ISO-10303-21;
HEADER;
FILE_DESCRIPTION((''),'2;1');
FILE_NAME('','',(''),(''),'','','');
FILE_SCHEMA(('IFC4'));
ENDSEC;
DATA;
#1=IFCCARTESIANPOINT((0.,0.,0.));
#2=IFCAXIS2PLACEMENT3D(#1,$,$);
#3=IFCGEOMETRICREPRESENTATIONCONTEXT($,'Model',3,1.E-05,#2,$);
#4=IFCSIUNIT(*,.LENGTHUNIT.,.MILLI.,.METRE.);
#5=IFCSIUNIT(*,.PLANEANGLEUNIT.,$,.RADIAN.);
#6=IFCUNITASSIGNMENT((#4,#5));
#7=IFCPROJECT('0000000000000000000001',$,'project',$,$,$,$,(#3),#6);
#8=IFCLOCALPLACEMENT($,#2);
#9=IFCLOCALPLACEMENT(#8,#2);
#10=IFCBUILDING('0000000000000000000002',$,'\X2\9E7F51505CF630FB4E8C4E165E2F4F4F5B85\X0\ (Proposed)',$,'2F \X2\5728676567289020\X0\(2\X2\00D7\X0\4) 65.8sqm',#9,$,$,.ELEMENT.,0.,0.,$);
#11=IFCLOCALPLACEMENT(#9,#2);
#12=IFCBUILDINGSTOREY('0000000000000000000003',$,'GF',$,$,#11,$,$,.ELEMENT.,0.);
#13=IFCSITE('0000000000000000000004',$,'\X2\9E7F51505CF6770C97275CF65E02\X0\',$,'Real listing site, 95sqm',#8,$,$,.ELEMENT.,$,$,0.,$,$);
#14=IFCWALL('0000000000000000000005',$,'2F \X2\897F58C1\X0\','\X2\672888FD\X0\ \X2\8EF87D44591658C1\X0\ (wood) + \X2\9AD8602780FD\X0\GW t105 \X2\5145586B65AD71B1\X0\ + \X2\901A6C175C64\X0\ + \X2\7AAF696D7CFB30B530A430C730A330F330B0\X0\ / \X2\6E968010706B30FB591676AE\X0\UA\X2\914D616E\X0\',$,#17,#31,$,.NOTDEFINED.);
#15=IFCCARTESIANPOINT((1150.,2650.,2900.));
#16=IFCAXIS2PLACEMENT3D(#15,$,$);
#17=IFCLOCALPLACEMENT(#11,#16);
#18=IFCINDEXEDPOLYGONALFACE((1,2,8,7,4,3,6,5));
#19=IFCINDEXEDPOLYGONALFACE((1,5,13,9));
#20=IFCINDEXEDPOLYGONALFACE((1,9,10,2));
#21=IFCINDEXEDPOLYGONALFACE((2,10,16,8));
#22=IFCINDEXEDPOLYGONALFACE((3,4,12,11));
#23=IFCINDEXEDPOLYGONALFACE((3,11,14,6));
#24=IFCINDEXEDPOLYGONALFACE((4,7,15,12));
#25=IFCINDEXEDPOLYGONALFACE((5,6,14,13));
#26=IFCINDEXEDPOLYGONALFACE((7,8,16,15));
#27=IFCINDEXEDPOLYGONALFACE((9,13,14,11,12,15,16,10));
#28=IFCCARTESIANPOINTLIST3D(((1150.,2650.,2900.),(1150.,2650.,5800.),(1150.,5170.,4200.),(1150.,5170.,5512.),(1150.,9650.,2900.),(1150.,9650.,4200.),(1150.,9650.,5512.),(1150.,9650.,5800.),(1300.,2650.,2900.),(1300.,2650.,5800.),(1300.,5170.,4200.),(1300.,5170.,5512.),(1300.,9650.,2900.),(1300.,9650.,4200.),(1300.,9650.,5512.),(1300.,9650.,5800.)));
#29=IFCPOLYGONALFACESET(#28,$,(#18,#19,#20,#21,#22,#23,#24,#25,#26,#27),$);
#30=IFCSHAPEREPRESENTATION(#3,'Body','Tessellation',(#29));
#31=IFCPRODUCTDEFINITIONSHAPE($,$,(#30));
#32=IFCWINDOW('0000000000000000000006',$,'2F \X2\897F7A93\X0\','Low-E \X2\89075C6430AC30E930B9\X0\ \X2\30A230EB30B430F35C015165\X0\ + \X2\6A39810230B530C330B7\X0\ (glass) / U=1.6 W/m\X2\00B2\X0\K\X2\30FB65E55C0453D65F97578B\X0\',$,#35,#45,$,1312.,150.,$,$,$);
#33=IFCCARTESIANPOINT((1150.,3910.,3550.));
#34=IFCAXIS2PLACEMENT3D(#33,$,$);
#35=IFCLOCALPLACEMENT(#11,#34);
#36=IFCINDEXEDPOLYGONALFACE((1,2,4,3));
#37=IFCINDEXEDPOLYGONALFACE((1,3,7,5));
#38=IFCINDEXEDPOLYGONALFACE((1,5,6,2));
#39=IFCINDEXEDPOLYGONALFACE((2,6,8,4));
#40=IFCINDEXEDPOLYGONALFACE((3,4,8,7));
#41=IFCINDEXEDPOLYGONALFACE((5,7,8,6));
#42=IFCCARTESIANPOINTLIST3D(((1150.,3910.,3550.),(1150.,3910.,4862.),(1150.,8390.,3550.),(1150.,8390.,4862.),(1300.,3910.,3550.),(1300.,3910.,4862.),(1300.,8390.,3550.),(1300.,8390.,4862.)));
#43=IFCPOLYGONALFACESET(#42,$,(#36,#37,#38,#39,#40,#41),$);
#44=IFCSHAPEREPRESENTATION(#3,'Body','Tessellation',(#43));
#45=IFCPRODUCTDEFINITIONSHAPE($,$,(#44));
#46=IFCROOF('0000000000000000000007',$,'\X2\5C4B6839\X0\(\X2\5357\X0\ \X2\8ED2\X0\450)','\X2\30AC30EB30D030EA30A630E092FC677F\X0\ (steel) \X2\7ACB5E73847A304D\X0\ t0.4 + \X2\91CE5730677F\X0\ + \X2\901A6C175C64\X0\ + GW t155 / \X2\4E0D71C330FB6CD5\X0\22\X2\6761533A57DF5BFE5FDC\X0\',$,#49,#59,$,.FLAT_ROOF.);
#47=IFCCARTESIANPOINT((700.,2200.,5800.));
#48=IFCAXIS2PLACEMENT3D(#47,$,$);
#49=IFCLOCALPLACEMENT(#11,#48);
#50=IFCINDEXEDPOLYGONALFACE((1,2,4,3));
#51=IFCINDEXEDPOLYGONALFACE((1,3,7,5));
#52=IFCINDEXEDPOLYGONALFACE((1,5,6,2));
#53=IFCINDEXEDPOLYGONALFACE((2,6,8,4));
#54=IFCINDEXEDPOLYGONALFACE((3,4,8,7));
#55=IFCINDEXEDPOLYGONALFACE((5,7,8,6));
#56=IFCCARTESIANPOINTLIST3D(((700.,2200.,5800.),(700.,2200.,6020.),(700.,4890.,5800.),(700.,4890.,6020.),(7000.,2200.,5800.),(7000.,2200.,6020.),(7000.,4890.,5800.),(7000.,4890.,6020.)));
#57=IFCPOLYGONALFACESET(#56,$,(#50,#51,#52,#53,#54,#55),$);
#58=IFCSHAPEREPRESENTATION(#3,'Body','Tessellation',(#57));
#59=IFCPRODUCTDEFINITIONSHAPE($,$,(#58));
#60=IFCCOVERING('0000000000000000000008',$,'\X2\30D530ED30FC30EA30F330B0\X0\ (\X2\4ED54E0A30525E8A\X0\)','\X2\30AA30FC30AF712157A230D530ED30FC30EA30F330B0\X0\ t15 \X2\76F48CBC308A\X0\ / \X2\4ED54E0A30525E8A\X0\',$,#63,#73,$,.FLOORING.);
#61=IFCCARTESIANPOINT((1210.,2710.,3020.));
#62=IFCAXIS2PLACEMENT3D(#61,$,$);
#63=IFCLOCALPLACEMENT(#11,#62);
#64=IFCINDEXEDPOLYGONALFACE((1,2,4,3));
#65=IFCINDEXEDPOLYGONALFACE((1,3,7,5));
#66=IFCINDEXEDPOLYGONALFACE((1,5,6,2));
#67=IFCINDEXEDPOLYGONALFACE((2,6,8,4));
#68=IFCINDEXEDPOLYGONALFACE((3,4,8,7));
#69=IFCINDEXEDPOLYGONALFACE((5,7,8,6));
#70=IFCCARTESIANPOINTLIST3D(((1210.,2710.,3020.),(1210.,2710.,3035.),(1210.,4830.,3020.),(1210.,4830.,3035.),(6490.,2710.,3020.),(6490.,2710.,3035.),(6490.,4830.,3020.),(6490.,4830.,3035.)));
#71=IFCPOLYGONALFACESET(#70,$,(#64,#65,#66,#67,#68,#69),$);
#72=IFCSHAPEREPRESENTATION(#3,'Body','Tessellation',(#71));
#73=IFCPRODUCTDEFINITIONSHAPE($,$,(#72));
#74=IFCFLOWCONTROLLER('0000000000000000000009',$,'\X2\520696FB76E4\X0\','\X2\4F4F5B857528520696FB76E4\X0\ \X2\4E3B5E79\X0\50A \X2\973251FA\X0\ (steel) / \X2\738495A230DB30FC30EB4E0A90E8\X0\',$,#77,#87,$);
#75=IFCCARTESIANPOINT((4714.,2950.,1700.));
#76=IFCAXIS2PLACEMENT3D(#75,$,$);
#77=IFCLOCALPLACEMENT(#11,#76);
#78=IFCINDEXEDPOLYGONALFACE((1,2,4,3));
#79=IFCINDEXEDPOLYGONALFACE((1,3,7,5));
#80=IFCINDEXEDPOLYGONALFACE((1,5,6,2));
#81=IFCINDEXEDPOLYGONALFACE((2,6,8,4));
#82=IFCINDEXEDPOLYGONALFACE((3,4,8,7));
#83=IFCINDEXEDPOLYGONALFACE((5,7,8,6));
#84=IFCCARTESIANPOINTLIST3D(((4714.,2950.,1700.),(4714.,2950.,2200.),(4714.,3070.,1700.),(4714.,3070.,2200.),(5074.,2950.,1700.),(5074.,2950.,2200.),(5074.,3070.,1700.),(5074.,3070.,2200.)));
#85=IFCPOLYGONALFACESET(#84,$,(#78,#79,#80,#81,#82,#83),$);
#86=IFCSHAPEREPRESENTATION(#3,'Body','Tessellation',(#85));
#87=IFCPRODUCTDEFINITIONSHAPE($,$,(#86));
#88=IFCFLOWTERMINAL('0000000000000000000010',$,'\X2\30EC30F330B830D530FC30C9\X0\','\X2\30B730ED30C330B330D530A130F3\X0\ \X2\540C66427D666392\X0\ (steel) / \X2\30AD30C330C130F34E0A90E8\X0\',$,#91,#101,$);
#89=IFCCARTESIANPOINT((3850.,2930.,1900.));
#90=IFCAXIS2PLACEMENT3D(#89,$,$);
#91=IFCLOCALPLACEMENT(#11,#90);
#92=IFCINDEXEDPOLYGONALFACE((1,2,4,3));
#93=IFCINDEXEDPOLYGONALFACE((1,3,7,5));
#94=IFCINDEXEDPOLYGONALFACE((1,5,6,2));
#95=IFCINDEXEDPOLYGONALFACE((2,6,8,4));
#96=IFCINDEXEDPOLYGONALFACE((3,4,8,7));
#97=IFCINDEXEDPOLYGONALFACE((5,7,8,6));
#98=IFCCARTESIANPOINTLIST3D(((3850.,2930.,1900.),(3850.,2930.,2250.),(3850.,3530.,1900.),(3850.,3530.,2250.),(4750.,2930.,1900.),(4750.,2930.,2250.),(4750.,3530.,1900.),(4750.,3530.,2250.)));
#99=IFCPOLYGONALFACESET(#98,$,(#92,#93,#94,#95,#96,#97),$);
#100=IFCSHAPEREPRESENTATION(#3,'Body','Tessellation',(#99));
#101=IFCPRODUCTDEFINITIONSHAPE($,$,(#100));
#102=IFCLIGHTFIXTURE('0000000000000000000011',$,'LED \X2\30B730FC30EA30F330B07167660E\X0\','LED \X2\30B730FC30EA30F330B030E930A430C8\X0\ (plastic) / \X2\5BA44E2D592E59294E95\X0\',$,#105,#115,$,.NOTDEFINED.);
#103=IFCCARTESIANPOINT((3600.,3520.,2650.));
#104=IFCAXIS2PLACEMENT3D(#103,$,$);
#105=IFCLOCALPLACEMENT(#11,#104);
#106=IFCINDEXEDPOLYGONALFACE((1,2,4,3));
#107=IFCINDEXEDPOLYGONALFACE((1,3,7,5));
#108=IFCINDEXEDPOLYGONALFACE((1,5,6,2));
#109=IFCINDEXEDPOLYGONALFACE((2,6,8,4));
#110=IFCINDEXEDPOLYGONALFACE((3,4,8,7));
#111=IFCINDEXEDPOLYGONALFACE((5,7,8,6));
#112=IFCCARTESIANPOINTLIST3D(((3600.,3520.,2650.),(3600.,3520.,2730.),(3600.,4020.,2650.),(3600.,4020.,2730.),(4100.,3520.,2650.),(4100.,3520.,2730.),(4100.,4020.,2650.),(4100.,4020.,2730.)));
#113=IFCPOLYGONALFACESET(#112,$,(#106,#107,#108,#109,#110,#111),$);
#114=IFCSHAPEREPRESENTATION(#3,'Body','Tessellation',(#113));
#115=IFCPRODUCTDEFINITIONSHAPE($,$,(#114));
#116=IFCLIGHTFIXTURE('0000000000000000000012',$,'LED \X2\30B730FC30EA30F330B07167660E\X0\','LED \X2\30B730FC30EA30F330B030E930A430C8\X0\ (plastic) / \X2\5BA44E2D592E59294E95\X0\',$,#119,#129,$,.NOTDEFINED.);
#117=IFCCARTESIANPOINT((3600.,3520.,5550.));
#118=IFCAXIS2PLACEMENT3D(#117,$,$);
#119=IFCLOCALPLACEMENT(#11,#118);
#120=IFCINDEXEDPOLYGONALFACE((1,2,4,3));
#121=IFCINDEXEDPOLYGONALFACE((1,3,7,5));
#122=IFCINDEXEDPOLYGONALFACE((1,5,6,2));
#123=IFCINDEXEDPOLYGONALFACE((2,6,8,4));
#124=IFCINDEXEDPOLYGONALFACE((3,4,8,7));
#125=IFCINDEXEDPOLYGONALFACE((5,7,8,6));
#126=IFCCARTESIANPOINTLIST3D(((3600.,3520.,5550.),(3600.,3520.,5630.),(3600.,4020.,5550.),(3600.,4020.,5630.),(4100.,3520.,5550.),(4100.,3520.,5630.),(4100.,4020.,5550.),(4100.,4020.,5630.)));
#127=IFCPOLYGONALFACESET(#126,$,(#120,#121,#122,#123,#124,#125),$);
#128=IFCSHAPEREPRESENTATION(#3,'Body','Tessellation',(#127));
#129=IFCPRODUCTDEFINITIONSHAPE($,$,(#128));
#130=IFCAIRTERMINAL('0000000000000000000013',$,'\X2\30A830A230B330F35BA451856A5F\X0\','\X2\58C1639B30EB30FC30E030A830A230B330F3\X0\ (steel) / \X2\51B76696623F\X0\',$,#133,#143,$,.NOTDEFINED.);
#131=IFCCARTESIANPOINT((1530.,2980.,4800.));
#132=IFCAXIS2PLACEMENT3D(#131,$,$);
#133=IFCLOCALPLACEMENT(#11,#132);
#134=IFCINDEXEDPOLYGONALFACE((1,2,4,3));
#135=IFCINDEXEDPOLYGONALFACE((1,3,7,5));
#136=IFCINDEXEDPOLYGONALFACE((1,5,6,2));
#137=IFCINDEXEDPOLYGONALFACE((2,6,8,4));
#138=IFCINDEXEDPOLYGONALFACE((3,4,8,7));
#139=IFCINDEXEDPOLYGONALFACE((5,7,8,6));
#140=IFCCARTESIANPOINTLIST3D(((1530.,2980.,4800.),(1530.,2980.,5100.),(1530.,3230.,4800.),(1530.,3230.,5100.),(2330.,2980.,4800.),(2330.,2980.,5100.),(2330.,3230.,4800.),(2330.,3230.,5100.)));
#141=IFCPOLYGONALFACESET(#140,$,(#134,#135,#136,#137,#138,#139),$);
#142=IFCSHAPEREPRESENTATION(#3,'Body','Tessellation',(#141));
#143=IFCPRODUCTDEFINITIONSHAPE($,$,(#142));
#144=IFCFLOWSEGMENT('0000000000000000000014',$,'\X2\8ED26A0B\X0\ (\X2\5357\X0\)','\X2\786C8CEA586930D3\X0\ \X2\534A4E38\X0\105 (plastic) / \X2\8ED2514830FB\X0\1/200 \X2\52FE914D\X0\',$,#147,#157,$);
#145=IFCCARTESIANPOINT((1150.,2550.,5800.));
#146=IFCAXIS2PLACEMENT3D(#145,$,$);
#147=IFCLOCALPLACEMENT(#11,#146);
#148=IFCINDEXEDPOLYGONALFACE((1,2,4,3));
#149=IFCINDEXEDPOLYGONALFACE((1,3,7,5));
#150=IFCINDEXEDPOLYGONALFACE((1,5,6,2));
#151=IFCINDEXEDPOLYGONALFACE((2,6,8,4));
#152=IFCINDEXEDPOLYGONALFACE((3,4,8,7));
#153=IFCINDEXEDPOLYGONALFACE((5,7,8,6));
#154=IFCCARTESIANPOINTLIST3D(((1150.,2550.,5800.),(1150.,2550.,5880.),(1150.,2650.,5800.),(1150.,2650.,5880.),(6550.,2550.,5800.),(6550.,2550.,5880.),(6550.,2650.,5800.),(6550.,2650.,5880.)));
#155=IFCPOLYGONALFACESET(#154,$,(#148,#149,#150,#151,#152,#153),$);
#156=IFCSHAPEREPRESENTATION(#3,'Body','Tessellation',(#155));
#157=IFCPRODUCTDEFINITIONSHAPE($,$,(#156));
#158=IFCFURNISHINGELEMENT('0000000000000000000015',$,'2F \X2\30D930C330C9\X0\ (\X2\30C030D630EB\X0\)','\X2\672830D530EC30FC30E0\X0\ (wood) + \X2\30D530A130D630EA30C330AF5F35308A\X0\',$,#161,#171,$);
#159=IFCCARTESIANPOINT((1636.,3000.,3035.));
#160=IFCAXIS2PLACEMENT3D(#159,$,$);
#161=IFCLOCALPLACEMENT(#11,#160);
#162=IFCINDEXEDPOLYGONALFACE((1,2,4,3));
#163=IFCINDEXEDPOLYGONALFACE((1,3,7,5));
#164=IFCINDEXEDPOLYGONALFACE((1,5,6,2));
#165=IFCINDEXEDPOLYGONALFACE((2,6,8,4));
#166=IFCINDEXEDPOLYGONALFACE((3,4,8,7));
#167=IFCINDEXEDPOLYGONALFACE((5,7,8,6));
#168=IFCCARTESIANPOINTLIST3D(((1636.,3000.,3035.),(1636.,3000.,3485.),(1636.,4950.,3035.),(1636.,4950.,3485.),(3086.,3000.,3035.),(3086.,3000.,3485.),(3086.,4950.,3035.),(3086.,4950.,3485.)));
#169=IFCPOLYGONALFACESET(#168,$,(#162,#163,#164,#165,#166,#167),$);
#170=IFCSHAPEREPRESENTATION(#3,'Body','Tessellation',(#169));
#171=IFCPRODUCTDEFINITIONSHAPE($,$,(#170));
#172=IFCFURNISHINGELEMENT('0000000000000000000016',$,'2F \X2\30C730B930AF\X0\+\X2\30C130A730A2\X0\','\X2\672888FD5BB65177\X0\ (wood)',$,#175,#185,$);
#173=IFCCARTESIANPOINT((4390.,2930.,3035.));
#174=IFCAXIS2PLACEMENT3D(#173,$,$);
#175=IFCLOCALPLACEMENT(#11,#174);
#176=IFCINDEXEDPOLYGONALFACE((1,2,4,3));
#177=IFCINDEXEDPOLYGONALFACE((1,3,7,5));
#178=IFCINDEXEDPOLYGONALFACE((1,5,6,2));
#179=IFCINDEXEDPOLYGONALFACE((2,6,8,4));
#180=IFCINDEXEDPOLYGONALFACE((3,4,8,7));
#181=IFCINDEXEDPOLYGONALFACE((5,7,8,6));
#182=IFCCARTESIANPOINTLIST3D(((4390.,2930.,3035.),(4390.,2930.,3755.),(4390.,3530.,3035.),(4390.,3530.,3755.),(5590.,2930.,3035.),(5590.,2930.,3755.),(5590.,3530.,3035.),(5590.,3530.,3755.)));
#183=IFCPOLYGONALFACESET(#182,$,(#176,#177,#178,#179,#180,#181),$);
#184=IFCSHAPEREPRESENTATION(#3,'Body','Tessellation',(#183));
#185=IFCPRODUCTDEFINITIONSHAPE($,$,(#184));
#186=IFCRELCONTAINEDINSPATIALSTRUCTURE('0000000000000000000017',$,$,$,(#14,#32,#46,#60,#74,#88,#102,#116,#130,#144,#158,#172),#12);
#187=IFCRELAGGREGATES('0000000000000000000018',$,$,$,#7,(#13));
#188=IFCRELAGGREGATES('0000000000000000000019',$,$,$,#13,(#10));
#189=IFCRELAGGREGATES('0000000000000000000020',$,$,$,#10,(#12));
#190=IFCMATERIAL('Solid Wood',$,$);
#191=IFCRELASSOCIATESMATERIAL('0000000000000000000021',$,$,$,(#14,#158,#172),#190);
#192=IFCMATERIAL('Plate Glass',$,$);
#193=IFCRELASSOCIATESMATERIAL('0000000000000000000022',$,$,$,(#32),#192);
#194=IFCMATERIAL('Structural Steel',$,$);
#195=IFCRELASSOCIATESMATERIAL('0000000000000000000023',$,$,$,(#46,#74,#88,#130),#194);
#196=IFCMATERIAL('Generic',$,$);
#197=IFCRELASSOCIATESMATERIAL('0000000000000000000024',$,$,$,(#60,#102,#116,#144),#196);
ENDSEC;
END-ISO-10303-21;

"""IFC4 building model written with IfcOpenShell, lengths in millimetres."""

from ifc_helpers import new_model, si_unit, frame, frame_2d, origin, place, context, project, spatial, rectangle, extrude, material, element, fill, save


model = new_model("IFC4")

# Units and contexts
model_context = context("Model", 3, precision=1e-05, world=origin())
ifc_project = project(units=[si_unit("LENGTHUNIT", "METRE", prefix="MILLI"), si_unit("PLANEANGLEUNIT", "RADIAN")], contexts=[model_context])

# Site, building, storey
site_placement = place(None, origin())
site = spatial("IfcSite", under=ifc_project, at=site_placement, Name="鹿児島県霧島市", ObjectType="Real listing site, 95sqm", CompositionType="ELEMENT", RefElevation=0.0)
building_placement = place(site_placement, origin())
building = spatial("IfcBuilding", under=site, at=building_placement, Name="鹿児島・二世帯住宅 (Proposed)", ObjectType="2F 在来木造(2×4) 65.8sqm", CompositionType="ELEMENT", ElevationOfRefHeight=0.0, ElevationOfTerrain=0.0)
storey_placement = place(building_placement, origin())
storey = spatial("IfcBuildingStorey", under=building, at=storey_placement, Name="GF", CompositionType="ELEMENT", Elevation=0.0)

# Shared definitions
ifc_material_1 = material(Name="Solid Wood")

# Wall, opening, window
ifc_material_2 = material(Name="Plate Glass")
wall_1_placement = place(storey_placement, frame((1150.0, 2650.0, 2900.0)))
wall_1 = element("IfcWall", 1, at=wall_1_placement, inside=storey, material=ifc_material_1, Name="2F 西壁", Description="木製 軸組外壁 (wood) + 高性能GW t105 充填断熱 + 通気層 + 窯業系サイディング / 準耐火・外皮UA配慮", PredefinedType="NOTDEFINED", context=model_context, shape_type="SweptSolid", body=[
    extrude(rectangle(XDim=150.0, YDim=7000.0, at=frame_2d((75.0, 3500.0))), frame((1150.0, 2650.0, 2900.0)), (0.0, 0.0, 1.0), 2900.0),
])
opening_1_placement = place(storey_placement, frame((1150.0, 3910.0, 3550.0)))
opening_1 = element("IfcOpeningElement", 2, at=opening_1_placement, cuts=wall_1, PredefinedType="NOTDEFINED", context=model_context, shape_type="SweptSolid", body=[
    extrude(rectangle(XDim=150.0, YDim=4480.0, at=frame_2d((75.0, 2240.0))), frame((1150.0, 3910.0, 3550.0)), (0.0, 0.0, 1.0), 1312.0),
])
window_1_placement = place(storey_placement, frame((1150.0, 3910.0, 3550.0)))
window_1 = element("IfcWindow", 3, at=window_1_placement, inside=storey, material=ifc_material_2, Name="2F 西窓", Description="Low-E 複層ガラス アルゴン封入 + 樹脂サッシ (glass) / U=1.6 W/m²K・日射取得型", OverallHeight=1312.0, OverallWidth=150.0, context=model_context, shape_type="SweptSolid", body=[
    extrude(rectangle(XDim=150.0, YDim=4480.0, at=frame_2d((75.0, 2240.0))), frame((1150.0, 3910.0, 3550.0)), (0.0, 0.0, 1.0), 1312.0),
])
fill(opening_1, window_1)

# Roof
ifc_material_3 = material(Name="Structural Steel")
for number, where, name in (
    (4, (700.0, 2200.0, 5800.0), "屋根(南 軒450)"),
):
    element("IfcRoof", number, at=place(storey_placement, frame(where)), inside=storey, material=ifc_material_3, Name=name, Description="ガルバリウム鋼板 (steel) 立平葺き t0.4 + 野地板 + 通気層 + GW t155 / 不燃・法22条区域対応", PredefinedType="FLAT_ROOF", context=model_context, shape_type="SweptSolid", body=[
        extrude(rectangle(XDim=6300.0, YDim=2690.0, at=frame_2d((3150.0, 1345.0))), frame((700.0, 2200.0, 5800.0)), (0.0, 0.0, 1.0), 220.0),
    ])

# Covering
ifc_material_4 = material(Name="Generic")
covering_placement = place(storey_placement, frame((1210.0, 2710.0, 3020.0)))
element("IfcCovering", 5, at=covering_placement, inside=storey, material=ifc_material_4, Name="フローリング (仕上げ床)", Description="オーク無垢フローリング t15 直貼り / 仕上げ床", PredefinedType="FLOORING", context=model_context, shape_type="SweptSolid", body=[
    extrude(rectangle(XDim=5280.0, YDim=2120.0, at=frame_2d((2640.0, 1060.0))), frame((1210.0, 2710.0, 3020.0)), (0.0, 0.0, 1.0), 15.0),
])

# Flow controller
flow_controller_placement = place(storey_placement, frame((4714.0, 2950.0, 1700.0)))
element("IfcFlowController", 6, at=flow_controller_placement, inside=storey, material=ifc_material_3, Name="分電盤", Description="住宅用分電盤 主幹50A 露出 (steel) / 玄関ホール上部", context=model_context, shape_type="SweptSolid", body=[
    extrude(rectangle(XDim=360.0, YDim=120.0, at=frame_2d((180.0, 60.0))), frame((4714.0, 2950.0, 1700.0)), (0.0, 0.0, 1.0), 500.0),
])

# Flow terminal
flow_terminal_placement = place(storey_placement, frame((3850.0, 2930.0, 1900.0)))
element("IfcFlowTerminal", 7, at=flow_terminal_placement, inside=storey, material=ifc_material_3, Name="レンジフード", Description="シロッコファン 同時給排 (steel) / キッチン上部", context=model_context, shape_type="SweptSolid", body=[
    extrude(rectangle(XDim=900.0, YDim=600.0, at=frame_2d((450.0, 300.0))), frame((3850.0, 2930.0, 1900.0)), (0.0, 0.0, 1.0), 350.0),
])

# Light fixtures
light_fixture_1_placement = place(storey_placement, frame((3600.0, 3520.0, 2650.0)))
element("IfcLightFixture", 8, at=light_fixture_1_placement, inside=storey, material=ifc_material_4, Name="LED シーリング照明", Description="LED シーリングライト (plastic) / 室中央天井", PredefinedType="NOTDEFINED", context=model_context, shape_type="SweptSolid", body=[
    extrude(rectangle(XDim=500.0, YDim=500.0, at=frame_2d((250.0, 250.0))), frame((3600.0, 3520.0, 2650.0)), (0.0, 0.0, 1.0), 80.0),
])
light_fixture_2_placement = place(storey_placement, frame((3600.0, 3520.0, 5550.0)))
element("IfcLightFixture", 9, at=light_fixture_2_placement, inside=storey, material=ifc_material_4, Name="LED シーリング照明", Description="LED シーリングライト (plastic) / 室中央天井", PredefinedType="NOTDEFINED", context=model_context, shape_type="SweptSolid", body=[
    extrude(rectangle(XDim=500.0, YDim=500.0, at=frame_2d((250.0, 250.0))), frame((3600.0, 3520.0, 5550.0)), (0.0, 0.0, 1.0), 80.0),
])

# Air terminal
air_terminal_placement = place(storey_placement, frame((1530.0, 2980.0, 4800.0)))
element("IfcAirTerminal", 10, at=air_terminal_placement, inside=storey, material=ifc_material_3, Name="エアコン室内機", Description="壁掛ルームエアコン (steel) / 冷暖房", PredefinedType="NOTDEFINED", context=model_context, shape_type="SweptSolid", body=[
    extrude(rectangle(XDim=800.0, YDim=250.0, at=frame_2d((400.0, 125.0))), frame((1530.0, 2980.0, 4800.0)), (0.0, 0.0, 1.0), 300.0),
])

# Flow segment
flow_segment_placement = place(storey_placement, frame((1150.0, 2550.0, 5800.0)))
element("IfcFlowSegment", 11, at=flow_segment_placement, inside=storey, material=ifc_material_4, Name="軒樋 (南)", Description="硬質塩ビ 半丸105 (plastic) / 軒先・1/200 勾配", context=model_context, shape_type="SweptSolid", body=[
    extrude(rectangle(XDim=5400.0, YDim=100.0, at=frame_2d((2700.0, 50.0))), frame((1150.0, 2550.0, 5800.0)), (0.0, 0.0, 1.0), 80.0),
])

# Furnishing elements
furnishing_1_placement = place(storey_placement, frame((1636.0, 3000.0, 3035.0)))
element("IfcFurnishingElement", 12, at=furnishing_1_placement, inside=storey, material=ifc_material_1, Name="2F ベッド (ダブル)", Description="木フレーム (wood) + ファブリック張り", context=model_context, shape_type="SweptSolid", body=[
    extrude(rectangle(XDim=1450.0, YDim=1950.0, at=frame_2d((725.0, 975.0))), frame((1636.0, 3000.0, 3035.0)), (0.0, 0.0, 1.0), 450.0),
])
furnishing_2_placement = place(storey_placement, frame((4390.0, 2930.0, 3035.0)))
element("IfcFurnishingElement", 13, at=furnishing_2_placement, inside=storey, material=ifc_material_1, Name="2F デスク+チェア", Description="木製家具 (wood)", context=model_context, shape_type="SweptSolid", body=[
    extrude(rectangle(XDim=1200.0, YDim=600.0, at=frame_2d((600.0, 300.0))), frame((4390.0, 2930.0, 3035.0)), (0.0, 0.0, 1.0), 720.0),
])

save(model, "model.ifc")
